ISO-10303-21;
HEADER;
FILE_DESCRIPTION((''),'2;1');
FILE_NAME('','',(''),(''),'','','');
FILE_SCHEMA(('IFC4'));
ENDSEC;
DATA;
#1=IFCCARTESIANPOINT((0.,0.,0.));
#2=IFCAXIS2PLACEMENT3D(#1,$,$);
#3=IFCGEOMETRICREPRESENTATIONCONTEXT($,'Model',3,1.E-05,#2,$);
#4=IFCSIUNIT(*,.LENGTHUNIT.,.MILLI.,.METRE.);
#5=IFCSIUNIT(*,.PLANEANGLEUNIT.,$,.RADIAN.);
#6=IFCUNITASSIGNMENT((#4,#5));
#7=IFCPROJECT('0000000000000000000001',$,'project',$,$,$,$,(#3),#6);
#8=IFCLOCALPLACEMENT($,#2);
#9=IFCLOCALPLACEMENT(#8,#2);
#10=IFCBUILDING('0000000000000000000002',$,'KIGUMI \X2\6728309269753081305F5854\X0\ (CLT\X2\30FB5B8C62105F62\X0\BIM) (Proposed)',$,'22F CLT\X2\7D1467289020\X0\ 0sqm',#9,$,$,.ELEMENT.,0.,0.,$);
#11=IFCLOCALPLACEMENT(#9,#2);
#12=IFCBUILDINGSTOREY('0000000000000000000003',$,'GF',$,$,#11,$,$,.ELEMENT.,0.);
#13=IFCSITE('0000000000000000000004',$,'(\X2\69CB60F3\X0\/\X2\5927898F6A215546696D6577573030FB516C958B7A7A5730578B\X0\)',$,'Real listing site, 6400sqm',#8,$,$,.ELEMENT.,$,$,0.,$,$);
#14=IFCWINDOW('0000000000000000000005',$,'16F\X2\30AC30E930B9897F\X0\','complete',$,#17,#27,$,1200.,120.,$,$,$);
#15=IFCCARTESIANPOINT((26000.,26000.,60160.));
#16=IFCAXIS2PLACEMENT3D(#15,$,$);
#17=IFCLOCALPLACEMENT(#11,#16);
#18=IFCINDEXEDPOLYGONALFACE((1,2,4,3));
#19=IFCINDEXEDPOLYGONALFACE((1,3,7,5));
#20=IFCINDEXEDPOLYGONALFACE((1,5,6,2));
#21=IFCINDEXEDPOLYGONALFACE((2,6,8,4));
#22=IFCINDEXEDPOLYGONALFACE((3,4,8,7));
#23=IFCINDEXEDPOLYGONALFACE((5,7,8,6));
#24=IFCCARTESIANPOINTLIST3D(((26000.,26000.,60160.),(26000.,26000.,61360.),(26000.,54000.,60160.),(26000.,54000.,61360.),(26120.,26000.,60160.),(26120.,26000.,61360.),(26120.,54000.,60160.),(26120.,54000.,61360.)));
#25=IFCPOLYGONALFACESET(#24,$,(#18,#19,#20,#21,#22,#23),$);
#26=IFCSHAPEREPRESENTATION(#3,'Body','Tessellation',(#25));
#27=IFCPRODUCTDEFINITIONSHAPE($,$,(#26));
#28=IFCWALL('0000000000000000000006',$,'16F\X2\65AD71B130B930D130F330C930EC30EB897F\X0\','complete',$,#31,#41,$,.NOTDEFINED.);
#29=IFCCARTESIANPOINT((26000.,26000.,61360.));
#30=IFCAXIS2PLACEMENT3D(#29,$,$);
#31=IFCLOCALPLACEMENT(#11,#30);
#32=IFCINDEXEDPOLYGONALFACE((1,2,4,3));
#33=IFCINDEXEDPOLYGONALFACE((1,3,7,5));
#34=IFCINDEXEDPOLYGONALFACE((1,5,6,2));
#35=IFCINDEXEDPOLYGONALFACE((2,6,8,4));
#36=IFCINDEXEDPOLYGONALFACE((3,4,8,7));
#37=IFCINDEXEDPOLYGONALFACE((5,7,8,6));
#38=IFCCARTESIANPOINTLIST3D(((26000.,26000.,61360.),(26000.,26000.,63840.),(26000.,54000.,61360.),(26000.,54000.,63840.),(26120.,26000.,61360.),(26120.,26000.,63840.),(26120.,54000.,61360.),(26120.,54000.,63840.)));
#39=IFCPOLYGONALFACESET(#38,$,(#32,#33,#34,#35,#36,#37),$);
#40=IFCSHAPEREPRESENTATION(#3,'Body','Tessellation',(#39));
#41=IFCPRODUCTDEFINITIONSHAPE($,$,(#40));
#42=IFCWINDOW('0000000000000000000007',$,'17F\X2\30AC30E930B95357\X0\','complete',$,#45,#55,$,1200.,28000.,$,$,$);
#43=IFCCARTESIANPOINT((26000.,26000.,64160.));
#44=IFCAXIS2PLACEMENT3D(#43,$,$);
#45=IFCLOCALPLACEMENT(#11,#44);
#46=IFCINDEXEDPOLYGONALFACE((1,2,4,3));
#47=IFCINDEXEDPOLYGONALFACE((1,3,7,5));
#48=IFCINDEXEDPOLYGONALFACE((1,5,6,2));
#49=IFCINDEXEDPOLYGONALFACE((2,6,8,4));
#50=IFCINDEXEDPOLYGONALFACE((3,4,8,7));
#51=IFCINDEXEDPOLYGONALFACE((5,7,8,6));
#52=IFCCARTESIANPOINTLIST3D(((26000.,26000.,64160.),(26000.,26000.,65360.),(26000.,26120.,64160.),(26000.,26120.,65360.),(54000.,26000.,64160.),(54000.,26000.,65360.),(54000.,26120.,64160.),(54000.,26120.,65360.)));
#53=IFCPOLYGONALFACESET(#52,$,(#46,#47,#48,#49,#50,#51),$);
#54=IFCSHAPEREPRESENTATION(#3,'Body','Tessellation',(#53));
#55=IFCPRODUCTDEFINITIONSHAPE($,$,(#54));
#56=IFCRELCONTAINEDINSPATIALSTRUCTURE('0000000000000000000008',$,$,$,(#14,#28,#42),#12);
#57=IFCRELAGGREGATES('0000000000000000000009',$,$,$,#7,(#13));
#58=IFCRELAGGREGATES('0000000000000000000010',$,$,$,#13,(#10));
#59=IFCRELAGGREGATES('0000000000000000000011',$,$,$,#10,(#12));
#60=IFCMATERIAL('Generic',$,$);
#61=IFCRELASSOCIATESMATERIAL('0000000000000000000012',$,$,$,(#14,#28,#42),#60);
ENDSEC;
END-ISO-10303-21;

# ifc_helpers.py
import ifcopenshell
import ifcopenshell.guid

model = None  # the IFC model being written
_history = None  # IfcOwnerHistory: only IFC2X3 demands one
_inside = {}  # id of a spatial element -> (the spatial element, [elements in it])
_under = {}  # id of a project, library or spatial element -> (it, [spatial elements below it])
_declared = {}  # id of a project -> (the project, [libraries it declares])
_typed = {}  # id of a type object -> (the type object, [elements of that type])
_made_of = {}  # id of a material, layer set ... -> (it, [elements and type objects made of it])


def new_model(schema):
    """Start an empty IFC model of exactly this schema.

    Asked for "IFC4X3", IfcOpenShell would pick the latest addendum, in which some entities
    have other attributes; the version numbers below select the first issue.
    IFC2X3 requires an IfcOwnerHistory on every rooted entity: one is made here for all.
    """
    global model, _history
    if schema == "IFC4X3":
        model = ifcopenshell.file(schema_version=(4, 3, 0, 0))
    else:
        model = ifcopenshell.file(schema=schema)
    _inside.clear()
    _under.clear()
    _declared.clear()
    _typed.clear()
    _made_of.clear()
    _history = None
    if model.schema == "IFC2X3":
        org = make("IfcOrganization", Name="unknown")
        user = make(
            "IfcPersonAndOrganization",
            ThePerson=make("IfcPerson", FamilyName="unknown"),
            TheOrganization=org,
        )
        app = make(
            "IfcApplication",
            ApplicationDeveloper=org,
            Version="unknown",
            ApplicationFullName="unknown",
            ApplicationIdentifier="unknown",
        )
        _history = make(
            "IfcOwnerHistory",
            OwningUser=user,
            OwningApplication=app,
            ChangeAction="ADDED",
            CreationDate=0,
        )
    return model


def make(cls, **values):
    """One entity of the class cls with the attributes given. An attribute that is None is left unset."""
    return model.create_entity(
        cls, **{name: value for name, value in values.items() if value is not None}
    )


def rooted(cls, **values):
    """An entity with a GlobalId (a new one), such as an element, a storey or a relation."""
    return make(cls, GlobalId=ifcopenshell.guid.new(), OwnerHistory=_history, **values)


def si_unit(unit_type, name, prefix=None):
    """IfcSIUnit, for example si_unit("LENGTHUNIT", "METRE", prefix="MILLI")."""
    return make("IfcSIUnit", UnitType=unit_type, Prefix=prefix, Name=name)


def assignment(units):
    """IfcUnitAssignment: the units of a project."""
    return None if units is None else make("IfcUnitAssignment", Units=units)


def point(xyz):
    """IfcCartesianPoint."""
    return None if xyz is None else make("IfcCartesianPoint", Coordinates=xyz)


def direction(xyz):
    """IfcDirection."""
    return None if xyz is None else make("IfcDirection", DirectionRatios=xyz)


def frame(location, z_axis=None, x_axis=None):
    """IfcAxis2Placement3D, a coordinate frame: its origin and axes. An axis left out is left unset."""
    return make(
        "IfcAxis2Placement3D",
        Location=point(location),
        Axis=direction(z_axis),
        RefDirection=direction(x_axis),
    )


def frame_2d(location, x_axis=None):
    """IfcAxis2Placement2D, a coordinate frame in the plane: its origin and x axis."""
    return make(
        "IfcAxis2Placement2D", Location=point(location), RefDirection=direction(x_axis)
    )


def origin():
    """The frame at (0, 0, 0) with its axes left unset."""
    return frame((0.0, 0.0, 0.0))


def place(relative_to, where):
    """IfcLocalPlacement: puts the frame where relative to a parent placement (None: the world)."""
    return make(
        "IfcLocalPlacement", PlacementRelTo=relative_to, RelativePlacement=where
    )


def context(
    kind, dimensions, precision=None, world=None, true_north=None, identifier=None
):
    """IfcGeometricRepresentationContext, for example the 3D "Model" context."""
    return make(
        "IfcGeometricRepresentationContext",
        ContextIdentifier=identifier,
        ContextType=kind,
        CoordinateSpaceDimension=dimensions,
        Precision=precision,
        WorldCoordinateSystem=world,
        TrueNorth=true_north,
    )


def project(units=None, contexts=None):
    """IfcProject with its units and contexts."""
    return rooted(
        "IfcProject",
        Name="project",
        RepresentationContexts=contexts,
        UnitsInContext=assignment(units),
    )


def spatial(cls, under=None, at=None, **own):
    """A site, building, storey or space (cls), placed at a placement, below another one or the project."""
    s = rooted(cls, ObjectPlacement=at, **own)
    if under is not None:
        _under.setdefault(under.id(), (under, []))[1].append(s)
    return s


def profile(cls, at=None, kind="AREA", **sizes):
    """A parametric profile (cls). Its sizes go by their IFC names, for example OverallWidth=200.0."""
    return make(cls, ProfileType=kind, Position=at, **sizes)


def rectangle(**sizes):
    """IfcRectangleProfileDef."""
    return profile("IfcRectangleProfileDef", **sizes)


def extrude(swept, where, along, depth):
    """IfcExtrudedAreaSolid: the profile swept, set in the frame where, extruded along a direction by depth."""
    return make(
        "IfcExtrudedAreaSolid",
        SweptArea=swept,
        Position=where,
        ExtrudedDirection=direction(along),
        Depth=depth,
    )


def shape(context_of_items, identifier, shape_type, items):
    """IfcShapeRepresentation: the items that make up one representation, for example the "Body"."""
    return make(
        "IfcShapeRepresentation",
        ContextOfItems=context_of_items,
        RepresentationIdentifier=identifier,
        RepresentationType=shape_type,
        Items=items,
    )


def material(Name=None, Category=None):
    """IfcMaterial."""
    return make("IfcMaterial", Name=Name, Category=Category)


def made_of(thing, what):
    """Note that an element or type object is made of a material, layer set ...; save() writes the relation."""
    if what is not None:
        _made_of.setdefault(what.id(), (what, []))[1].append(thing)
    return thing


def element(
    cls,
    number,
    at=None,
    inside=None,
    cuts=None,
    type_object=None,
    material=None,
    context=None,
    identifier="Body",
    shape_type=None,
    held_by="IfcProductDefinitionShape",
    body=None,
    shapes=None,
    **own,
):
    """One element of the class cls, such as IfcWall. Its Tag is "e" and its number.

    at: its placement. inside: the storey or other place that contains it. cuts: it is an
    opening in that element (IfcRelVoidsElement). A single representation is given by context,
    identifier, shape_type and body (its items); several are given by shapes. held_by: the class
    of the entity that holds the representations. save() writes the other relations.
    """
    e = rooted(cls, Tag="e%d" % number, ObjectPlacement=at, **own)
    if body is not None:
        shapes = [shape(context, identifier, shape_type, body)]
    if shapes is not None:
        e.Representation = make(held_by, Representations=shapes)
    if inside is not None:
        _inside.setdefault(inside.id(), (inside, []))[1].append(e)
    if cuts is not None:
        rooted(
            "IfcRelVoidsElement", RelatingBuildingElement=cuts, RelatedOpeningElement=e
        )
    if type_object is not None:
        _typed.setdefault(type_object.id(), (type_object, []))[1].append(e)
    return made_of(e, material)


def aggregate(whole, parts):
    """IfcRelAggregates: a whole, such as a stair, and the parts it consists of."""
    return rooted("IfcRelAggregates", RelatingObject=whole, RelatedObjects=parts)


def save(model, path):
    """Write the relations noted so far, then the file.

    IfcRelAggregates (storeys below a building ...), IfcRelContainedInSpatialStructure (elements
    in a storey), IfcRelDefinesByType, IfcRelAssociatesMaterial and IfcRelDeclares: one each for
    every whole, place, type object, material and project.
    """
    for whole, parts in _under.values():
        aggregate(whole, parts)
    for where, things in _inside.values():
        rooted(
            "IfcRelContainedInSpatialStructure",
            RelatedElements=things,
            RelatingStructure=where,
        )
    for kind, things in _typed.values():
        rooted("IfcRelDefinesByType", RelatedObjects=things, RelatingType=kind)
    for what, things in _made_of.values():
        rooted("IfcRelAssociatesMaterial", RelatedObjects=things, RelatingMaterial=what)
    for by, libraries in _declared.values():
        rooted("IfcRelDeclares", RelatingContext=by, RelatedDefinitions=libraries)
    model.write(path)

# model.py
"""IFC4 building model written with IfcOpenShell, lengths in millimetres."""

from ifc_helpers import new_model, si_unit, frame, frame_2d, origin, place, context, project, spatial, rectangle, extrude, material, element, save


model = new_model("IFC4")

# Units and contexts
model_context = context("Model", 3, precision=1e-05, world=origin())
ifc_project = project(units=[si_unit("LENGTHUNIT", "METRE", prefix="MILLI"), si_unit("PLANEANGLEUNIT", "RADIAN")], contexts=[model_context])

# Site, building, storey
site_placement = place(None, origin())
site = spatial("IfcSite", under=ifc_project, at=site_placement, Name="(構想/大規模商業敷地・公開空地型)", ObjectType="Real listing site, 6400sqm", CompositionType="ELEMENT", RefElevation=0.0)
building_placement = place(site_placement, origin())
building = spatial("IfcBuilding", under=site, at=building_placement, Name="KIGUMI 木を極めた塔 (CLT・完成形BIM) (Proposed)", ObjectType="22F CLT純木造 0sqm", CompositionType="ELEMENT", ElevationOfRefHeight=0.0, ElevationOfTerrain=0.0)
storey_placement = place(building_placement, origin())
storey = spatial("IfcBuildingStorey", under=building, at=storey_placement, Name="GF", CompositionType="ELEMENT", Elevation=0.0)

# Shared definitions
ifc_material = material(Name="Generic")

# Window
window_1_placement = place(storey_placement, frame((26000.0, 26000.0, 60160.0)))
element("IfcWindow", 1, at=window_1_placement, inside=storey, material=ifc_material, Name="16Fガラス西", Description="complete", OverallHeight=1200.0, OverallWidth=120.0, context=model_context, shape_type="SweptSolid", body=[
    extrude(rectangle(XDim=120.0, YDim=28000.0, at=frame_2d((60.0, 14000.0))), frame((26000.0, 26000.0, 60160.0)), (0.0, 0.0, 1.0), 1200.0),
])

# Wall
wall_1_placement = place(storey_placement, frame((26000.0, 26000.0, 61360.0)))
element("IfcWall", 2, at=wall_1_placement, inside=storey, material=ifc_material, Name="16F断熱スパンドレル西", Description="complete", PredefinedType="NOTDEFINED", context=model_context, shape_type="SweptSolid", body=[
    extrude(rectangle(XDim=120.0, YDim=28000.0, at=frame_2d((60.0, 14000.0))), frame((26000.0, 26000.0, 61360.0)), (0.0, 0.0, 1.0), 2480.0),
])

# Window
window_2_placement = place(storey_placement, frame((26000.0, 26000.0, 64160.0)))
element("IfcWindow", 3, at=window_2_placement, inside=storey, material=ifc_material, Name="17Fガラス南", Description="complete", OverallHeight=1200.0, OverallWidth=28000.0, context=model_context, shape_type="SweptSolid", body=[
    extrude(rectangle(XDim=28000.0, YDim=120.0, at=frame_2d((14000.0, 60.0))), frame((26000.0, 26000.0, 64160.0)), (0.0, 0.0, 1.0), 1200.0),
])

save(model, "model.ifc")
